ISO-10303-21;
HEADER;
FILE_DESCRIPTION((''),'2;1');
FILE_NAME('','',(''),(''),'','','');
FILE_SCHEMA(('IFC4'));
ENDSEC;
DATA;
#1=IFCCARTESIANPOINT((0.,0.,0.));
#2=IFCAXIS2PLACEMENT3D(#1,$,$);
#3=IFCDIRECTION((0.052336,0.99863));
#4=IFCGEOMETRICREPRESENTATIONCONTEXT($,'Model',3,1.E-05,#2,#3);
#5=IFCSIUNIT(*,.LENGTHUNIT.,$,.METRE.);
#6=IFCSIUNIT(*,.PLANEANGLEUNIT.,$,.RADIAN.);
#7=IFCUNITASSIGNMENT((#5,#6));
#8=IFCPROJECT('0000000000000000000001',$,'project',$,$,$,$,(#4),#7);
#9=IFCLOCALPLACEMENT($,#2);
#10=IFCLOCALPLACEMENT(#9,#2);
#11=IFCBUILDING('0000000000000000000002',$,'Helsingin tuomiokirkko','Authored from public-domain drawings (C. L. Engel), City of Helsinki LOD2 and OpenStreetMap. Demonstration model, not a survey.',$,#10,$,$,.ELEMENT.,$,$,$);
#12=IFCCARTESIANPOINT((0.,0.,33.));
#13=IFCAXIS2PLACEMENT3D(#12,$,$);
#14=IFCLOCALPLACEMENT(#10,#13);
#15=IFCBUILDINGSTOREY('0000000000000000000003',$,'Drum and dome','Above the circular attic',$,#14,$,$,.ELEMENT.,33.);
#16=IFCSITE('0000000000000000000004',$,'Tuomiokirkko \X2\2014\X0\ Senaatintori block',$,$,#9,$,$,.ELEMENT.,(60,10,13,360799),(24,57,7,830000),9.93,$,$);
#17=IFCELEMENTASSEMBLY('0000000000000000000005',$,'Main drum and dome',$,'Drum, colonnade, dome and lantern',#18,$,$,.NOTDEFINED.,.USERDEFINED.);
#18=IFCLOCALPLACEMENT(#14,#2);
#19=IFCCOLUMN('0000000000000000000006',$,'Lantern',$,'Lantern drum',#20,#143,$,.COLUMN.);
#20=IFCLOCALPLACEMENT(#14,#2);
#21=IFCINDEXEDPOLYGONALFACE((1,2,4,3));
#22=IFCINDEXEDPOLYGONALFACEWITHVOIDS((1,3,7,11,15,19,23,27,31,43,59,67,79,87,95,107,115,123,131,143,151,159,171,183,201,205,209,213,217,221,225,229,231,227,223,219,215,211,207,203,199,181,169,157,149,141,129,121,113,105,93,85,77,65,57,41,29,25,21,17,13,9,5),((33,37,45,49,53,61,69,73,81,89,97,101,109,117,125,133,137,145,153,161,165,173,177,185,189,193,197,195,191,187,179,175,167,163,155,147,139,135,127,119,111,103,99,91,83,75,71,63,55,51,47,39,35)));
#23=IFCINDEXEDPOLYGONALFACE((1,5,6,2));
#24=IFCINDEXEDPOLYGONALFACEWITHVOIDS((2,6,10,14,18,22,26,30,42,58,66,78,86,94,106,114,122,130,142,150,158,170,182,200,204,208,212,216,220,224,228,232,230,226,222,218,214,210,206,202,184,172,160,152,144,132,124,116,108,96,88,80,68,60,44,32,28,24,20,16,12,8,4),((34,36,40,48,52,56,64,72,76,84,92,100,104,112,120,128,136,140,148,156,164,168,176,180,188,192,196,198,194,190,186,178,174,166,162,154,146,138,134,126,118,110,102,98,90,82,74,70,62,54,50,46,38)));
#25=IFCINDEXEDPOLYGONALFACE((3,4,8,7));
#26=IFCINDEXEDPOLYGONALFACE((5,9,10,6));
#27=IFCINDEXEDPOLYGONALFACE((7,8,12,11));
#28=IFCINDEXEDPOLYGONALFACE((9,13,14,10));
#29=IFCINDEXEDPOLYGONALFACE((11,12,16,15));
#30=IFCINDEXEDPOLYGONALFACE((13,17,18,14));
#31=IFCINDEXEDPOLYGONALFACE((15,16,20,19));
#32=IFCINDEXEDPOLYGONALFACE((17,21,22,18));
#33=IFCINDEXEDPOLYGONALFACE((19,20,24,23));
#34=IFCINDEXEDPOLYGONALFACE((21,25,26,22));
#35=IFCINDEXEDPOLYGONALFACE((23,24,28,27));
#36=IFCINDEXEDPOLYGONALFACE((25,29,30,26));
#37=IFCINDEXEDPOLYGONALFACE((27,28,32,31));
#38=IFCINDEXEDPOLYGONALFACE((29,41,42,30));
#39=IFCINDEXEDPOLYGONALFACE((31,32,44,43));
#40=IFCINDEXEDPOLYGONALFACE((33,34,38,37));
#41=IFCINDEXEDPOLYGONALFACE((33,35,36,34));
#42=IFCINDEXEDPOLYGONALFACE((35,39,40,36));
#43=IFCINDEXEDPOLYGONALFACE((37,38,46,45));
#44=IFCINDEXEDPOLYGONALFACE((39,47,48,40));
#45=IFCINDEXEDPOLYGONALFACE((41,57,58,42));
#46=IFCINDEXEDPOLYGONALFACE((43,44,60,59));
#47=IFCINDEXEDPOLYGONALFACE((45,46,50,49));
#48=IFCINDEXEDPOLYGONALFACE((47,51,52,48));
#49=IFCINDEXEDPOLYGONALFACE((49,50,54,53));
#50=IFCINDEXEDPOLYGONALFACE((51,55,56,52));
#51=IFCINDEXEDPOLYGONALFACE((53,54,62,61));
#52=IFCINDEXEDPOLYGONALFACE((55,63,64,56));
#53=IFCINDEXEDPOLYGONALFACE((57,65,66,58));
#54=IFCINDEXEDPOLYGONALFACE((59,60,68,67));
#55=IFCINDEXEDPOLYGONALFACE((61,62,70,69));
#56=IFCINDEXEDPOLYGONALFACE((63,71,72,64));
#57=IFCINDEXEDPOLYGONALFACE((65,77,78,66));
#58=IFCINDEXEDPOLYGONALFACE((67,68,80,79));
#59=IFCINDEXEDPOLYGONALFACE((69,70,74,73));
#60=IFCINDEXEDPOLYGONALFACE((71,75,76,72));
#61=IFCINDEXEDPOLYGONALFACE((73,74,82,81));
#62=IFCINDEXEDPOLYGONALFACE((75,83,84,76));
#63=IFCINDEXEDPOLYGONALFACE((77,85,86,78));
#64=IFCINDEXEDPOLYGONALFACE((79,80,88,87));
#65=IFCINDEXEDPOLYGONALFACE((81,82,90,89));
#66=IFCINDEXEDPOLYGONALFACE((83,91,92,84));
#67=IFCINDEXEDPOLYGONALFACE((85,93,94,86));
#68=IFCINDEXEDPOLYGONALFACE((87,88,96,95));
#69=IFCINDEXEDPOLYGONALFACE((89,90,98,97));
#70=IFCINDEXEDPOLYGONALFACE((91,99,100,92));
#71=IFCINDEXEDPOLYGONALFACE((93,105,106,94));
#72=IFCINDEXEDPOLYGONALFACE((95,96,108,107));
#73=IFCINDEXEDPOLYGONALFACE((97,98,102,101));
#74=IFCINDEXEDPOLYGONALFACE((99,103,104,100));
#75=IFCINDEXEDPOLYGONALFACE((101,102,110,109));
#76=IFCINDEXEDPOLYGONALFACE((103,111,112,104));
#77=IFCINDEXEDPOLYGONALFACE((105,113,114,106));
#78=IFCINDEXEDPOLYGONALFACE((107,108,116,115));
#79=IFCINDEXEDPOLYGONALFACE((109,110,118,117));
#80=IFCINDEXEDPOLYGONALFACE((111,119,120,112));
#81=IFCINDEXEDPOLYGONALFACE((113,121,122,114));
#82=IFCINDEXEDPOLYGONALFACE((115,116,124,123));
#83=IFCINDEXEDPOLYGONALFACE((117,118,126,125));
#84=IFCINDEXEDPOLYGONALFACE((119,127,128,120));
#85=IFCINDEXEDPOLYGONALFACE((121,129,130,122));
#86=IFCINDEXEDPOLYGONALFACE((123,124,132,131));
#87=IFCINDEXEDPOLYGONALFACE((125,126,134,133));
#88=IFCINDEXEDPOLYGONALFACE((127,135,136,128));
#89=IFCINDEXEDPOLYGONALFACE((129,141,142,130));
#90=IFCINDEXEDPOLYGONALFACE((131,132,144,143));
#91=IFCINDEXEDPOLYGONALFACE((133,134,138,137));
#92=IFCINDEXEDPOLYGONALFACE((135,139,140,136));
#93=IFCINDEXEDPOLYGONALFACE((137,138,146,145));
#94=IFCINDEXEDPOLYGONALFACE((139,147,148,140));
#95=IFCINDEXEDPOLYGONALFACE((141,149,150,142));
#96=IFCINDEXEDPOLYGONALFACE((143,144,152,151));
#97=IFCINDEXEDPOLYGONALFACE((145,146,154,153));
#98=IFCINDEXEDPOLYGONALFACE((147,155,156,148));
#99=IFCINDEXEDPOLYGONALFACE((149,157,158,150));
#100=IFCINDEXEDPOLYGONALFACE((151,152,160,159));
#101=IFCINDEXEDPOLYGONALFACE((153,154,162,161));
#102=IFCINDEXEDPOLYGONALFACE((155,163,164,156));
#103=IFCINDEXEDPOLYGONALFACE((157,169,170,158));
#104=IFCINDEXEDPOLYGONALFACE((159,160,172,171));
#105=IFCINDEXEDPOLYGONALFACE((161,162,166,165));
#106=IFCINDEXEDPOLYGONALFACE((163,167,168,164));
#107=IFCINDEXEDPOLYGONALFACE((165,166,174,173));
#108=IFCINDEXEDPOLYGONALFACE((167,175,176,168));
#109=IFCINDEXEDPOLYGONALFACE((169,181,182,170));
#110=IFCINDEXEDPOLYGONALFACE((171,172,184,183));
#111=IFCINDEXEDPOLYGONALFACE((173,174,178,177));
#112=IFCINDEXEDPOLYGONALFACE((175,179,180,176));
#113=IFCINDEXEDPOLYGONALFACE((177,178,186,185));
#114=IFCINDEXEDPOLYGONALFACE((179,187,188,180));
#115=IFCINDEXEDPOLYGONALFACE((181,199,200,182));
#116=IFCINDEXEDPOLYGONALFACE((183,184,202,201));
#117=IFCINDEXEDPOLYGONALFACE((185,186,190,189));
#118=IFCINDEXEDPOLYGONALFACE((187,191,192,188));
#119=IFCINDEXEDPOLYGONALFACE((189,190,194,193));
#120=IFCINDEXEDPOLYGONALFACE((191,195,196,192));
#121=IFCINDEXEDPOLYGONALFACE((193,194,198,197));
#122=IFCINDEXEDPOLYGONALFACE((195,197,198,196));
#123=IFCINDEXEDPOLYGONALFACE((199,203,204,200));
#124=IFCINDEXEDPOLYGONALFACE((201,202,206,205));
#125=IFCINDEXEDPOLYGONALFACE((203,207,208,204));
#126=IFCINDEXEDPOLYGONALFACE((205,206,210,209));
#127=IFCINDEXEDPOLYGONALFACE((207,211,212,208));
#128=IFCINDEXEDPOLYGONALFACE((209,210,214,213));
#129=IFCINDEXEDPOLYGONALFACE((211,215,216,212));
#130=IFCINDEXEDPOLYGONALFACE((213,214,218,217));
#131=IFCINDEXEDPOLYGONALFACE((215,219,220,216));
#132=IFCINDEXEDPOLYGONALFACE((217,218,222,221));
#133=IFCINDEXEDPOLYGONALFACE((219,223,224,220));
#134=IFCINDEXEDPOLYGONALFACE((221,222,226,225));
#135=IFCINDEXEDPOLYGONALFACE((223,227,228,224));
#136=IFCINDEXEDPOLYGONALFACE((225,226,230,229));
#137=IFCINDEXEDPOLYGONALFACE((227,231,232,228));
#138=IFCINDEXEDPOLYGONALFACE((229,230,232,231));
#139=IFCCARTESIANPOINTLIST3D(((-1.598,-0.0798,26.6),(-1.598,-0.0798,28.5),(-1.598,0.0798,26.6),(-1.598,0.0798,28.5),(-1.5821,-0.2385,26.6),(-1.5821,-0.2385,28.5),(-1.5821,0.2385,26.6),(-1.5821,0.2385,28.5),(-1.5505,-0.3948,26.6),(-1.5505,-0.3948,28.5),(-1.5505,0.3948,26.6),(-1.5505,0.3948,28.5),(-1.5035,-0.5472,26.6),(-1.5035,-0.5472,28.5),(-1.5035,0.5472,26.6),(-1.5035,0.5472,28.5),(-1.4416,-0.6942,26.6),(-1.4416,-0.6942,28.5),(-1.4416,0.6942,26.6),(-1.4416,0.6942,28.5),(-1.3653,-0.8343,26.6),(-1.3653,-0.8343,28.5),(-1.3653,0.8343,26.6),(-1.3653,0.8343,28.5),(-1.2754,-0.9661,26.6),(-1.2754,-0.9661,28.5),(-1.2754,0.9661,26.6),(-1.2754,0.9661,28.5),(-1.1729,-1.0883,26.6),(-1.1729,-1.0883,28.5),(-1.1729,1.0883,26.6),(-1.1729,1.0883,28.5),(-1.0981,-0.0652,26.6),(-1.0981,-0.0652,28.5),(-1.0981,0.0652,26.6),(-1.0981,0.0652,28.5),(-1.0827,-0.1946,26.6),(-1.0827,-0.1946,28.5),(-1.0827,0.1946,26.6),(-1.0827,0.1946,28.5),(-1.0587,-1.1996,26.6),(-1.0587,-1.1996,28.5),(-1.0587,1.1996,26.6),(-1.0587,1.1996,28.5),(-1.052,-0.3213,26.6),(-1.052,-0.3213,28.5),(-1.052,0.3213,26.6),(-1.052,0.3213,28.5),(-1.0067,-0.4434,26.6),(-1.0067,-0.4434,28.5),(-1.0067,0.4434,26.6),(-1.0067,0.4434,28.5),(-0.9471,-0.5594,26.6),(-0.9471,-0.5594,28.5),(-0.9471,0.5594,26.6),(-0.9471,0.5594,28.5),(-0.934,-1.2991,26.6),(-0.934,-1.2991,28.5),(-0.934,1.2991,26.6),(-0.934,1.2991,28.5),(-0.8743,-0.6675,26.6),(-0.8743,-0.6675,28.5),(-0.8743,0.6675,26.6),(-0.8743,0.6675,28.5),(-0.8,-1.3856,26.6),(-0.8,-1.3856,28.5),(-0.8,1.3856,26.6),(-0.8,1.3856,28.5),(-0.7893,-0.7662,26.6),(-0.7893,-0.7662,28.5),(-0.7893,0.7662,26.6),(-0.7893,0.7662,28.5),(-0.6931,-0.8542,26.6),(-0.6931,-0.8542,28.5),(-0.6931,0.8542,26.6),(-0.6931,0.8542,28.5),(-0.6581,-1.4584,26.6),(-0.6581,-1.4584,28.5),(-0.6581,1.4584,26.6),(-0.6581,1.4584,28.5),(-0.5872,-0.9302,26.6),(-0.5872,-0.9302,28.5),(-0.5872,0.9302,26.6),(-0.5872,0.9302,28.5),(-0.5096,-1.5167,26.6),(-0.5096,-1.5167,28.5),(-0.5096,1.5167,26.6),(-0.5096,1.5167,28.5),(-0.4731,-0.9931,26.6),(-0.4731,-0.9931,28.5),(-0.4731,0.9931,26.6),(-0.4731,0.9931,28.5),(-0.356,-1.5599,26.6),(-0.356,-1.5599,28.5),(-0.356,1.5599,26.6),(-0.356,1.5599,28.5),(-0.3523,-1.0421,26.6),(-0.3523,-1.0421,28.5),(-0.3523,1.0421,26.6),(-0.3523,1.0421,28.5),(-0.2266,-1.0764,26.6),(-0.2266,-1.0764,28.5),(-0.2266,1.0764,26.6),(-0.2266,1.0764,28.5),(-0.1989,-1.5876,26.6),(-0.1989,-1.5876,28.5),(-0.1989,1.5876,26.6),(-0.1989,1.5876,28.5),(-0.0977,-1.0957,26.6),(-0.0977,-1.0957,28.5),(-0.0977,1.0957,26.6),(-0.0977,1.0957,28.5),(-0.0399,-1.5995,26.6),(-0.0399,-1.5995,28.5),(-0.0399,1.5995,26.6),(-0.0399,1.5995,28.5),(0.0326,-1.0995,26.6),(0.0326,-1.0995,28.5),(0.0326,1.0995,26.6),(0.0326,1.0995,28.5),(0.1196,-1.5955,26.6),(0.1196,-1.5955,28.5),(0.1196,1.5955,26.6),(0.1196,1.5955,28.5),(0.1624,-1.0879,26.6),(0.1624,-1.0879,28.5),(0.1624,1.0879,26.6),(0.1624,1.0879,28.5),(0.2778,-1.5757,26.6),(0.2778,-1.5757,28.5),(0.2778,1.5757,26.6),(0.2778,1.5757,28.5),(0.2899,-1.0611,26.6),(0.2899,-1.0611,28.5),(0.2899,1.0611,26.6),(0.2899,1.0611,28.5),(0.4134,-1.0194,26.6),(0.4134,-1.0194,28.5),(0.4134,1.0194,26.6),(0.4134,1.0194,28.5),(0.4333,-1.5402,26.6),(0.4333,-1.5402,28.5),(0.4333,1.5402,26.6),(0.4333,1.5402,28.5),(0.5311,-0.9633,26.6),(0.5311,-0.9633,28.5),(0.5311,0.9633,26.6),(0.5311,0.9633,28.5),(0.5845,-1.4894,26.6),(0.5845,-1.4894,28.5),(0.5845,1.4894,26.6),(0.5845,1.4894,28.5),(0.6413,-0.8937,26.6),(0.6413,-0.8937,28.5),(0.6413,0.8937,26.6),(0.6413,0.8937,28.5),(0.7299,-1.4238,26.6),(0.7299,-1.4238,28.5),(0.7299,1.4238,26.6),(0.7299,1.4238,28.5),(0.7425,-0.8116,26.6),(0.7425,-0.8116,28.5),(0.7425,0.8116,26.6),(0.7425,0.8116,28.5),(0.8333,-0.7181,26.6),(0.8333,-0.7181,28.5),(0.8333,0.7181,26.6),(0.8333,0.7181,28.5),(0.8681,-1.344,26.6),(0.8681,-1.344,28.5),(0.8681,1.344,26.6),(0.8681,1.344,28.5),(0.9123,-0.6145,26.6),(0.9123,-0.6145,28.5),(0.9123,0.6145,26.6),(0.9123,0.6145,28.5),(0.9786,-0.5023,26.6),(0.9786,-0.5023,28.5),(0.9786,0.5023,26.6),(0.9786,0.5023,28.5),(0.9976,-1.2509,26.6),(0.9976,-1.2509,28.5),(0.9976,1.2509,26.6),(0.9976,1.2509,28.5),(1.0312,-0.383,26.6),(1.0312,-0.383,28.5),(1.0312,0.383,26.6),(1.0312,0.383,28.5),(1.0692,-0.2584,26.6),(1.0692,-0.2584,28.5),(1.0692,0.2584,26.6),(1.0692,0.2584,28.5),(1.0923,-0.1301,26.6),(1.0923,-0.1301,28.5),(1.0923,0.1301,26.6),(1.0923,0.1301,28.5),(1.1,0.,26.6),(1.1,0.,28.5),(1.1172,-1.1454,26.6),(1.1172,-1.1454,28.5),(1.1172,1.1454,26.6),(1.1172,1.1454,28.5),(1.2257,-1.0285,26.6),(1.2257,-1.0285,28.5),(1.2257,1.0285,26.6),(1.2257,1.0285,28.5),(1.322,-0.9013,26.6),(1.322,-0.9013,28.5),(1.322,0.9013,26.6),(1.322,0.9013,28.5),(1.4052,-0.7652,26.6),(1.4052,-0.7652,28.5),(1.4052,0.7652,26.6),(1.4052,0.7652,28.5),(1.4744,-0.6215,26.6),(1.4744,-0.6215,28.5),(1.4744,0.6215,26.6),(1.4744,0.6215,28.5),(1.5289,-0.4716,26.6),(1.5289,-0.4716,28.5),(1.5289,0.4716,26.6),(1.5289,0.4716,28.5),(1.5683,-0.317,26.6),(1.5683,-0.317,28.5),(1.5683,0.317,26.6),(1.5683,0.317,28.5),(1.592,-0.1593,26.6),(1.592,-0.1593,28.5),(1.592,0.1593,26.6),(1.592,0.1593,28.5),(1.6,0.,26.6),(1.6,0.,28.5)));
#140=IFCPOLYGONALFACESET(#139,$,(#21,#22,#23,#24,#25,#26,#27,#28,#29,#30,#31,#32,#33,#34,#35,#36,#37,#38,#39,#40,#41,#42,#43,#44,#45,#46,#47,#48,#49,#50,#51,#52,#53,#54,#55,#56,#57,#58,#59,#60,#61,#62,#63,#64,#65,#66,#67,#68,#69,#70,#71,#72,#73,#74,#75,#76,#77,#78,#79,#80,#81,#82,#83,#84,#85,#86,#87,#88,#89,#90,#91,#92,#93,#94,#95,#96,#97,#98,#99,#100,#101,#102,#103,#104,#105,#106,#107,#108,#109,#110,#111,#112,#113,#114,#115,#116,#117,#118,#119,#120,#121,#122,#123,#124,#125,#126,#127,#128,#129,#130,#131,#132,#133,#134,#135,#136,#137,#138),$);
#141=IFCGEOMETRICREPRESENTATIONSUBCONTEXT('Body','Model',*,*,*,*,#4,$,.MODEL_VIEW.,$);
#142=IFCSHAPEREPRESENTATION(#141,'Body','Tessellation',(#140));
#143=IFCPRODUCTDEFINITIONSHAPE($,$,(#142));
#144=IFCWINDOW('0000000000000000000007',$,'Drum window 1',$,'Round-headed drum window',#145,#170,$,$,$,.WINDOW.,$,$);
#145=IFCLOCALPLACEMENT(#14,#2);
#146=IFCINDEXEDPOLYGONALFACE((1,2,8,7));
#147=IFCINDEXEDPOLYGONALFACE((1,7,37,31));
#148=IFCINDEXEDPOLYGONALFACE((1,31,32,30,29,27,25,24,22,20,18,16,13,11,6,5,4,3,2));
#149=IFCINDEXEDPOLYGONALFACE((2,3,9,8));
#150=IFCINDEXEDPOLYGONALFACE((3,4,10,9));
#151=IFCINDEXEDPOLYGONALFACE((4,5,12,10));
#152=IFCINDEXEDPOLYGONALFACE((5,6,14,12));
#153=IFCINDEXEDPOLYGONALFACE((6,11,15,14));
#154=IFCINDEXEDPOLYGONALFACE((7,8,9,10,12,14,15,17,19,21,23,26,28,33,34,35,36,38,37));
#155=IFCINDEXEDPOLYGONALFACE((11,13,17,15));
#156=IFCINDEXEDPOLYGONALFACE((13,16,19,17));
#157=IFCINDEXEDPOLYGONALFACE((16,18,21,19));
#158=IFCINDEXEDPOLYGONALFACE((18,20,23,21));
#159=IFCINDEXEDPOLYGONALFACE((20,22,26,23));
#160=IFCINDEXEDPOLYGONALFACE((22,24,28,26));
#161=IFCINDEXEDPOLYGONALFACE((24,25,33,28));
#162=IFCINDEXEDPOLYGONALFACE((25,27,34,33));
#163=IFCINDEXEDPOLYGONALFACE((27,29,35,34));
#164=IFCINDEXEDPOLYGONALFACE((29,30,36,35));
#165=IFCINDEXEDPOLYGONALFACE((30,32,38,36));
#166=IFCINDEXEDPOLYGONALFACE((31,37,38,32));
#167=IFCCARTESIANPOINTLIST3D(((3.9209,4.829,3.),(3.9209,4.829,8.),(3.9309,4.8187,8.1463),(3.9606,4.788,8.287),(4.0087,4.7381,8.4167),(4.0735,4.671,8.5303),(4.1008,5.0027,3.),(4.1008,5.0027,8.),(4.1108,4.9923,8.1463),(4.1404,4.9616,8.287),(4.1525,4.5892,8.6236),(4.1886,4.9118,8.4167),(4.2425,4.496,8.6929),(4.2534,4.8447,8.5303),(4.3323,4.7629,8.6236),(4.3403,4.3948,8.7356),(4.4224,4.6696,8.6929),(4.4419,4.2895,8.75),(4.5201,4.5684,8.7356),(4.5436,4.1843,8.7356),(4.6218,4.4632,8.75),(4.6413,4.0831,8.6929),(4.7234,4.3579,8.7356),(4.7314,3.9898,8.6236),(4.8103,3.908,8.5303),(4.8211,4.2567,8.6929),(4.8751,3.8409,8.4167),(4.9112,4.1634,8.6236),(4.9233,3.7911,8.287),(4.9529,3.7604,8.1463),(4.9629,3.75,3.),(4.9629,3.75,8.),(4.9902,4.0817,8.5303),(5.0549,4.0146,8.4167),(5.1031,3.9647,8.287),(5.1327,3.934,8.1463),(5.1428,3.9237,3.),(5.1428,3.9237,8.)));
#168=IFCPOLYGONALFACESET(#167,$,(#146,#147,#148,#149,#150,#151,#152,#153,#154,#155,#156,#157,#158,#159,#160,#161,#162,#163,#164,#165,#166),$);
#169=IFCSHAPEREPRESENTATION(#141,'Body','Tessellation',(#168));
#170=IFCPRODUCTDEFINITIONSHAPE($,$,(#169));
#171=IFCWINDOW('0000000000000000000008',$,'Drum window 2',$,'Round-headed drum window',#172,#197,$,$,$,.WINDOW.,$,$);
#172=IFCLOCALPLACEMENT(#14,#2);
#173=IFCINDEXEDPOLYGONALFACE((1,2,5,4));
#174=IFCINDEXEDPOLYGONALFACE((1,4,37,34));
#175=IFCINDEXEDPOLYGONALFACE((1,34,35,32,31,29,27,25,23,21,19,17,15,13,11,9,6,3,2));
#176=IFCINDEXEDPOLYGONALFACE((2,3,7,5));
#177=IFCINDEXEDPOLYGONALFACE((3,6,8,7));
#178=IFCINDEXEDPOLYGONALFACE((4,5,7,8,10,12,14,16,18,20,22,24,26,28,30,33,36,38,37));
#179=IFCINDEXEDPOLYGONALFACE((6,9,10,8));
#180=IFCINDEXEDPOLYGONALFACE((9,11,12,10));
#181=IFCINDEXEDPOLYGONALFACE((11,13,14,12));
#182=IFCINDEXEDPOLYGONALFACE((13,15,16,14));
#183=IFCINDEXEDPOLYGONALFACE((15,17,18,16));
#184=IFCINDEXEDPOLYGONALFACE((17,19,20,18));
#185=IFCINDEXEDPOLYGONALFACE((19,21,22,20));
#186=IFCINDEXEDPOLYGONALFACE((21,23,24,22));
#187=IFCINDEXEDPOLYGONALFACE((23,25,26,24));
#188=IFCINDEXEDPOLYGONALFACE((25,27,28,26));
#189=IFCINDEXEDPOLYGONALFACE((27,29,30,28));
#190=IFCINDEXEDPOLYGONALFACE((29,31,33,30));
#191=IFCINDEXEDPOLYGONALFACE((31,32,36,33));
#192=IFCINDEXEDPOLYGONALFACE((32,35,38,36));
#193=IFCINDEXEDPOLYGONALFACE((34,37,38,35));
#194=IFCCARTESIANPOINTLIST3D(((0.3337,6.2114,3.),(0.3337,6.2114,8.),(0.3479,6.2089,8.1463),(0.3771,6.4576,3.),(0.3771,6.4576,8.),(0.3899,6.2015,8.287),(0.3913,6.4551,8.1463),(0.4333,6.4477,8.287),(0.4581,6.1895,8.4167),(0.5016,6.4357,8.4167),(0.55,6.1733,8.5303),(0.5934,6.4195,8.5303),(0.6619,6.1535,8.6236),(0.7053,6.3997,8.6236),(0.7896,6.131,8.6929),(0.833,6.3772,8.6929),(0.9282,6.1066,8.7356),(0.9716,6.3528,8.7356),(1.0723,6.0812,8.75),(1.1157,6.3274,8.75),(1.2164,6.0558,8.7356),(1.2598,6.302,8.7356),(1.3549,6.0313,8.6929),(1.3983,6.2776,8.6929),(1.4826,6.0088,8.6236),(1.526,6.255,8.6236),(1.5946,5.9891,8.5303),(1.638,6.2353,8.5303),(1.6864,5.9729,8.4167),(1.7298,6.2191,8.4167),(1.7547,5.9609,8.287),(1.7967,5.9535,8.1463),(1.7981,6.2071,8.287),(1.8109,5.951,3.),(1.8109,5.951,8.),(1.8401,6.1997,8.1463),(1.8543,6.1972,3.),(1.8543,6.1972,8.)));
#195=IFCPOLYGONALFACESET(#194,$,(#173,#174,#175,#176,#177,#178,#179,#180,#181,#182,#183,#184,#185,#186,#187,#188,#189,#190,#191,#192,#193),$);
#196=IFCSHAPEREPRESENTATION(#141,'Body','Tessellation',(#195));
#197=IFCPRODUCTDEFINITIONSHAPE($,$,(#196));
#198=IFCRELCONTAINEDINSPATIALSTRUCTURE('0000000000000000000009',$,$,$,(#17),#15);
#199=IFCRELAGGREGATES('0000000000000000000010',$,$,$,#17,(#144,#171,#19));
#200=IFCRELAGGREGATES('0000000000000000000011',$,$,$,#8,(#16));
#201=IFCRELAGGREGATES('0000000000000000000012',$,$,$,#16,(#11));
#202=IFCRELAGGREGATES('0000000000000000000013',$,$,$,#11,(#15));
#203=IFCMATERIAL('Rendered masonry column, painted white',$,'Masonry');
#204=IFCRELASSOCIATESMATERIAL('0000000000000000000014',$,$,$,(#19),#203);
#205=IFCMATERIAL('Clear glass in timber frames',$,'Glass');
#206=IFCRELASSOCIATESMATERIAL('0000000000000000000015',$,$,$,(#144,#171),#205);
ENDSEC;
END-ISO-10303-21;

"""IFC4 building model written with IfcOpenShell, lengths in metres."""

from ifc_helpers import new_model, si_unit, direction, frame, origin, origin_2d_with_axis, place, context, subcontext, project, spatial, polyline, hollow_circle, outline, extrude, material, element, aggregate, save


model = new_model("IFC4")

# Units and contexts
model_context = context("Model", 3, precision=1e-05, world=origin(), true_north=direction((0.052336, 0.99863)))
body_context = subcontext(model_context, "Body", "Model", "MODEL_VIEW")
ifc_project = project(units=[si_unit("LENGTHUNIT", "METRE"), si_unit("PLANEANGLEUNIT", "RADIAN")], contexts=[model_context])

# Site, building, storey
site_placement = place(None, origin())
site = spatial("IfcSite", under=ifc_project, at=site_placement, Name="Tuomiokirkko — Senaatintori block", CompositionType="ELEMENT", RefLatitude=(60, 10, 13, 360799), RefLongitude=(24, 57, 7, 830000), RefElevation=9.93)
building_placement = place(site_placement, origin())
building = spatial("IfcBuilding", under=site, at=building_placement, Name="Helsingin tuomiokirkko", Description="Authored from public-domain drawings (C. L. Engel), City of Helsinki LOD2 and OpenStreetMap. Demonstration model, not a survey.", CompositionType="ELEMENT")
storey_placement = place(building_placement, frame((0.0, 0.0, 33.0)))
storey = spatial("IfcBuildingStorey", under=building, at=storey_placement, Name="Drum and dome", Description="Above the circular attic", CompositionType="ELEMENT", Elevation=33.0)

# Element assembly, column, windows
assembly_placement = place(building_placement, origin())
assembly = element("IfcElementAssembly", 1, at=assembly_placement, inside=storey, Name="Main drum and dome", ObjectType="Drum, colonnade, dome and lantern", AssemblyPlace="NOTDEFINED", PredefinedType="USERDEFINED")
ifc_material_1 = material(Name="Rendered masonry column, painted white", Category="Masonry")
column_1_placement = place(building_placement, origin())
column_1 = element("IfcColumn", 2, at=column_1_placement, material=ifc_material_1, Name="Lantern", ObjectType="Lantern drum", PredefinedType="COLUMN", context=body_context, shape_type="SweptSolid", body=[
    extrude(hollow_circle(Radius=1.6, WallThickness=0.5, at=origin_2d_with_axis()), frame((0.0, 0.0, 59.6)), (0.0, 0.0, 1.0), 1.9),
])
ifc_material_2 = material(Name="Clear glass in timber frames", Category="Glass")
window_1_placement = place(building_placement, origin())
window_1 = element("IfcWindow", 3, at=window_1_placement, material=ifc_material_2, Name="Drum window 1", ObjectType="Round-headed drum window", PredefinedType="WINDOW", context=body_context, shape_type="SweptSolid", body=[
    extrude(outline(polyline([(-0.75, 0.0), (0.75, 0.0), (0.75, 5.0), (0.7356, 5.1463), (0.6929, 5.287), (0.6236, 5.4167), (0.5303, 5.5303), (0.4167, 5.6236), (0.287, 5.6929), (0.1463, 5.7356), (0.0, 5.75), (-0.1463, 5.7356), (-0.287, 5.6929), (-0.4167, 5.6236), (-0.5303, 5.5303), (-0.6236, 5.4167), (-0.6929, 5.287), (-0.7356, 5.1463), (-0.75, 5.0), (-0.75, 0.0)])), frame((4.4419, 4.2895, 36.0), z_axis=(0.71934, 0.694658, 0.0), x_axis=(-0.694658, 0.71934, 0.0)), (0.0, 0.0, 1.0), 0.25),
])
window_2_placement = place(building_placement, origin())
window_2 = element("IfcWindow", 4, at=window_2_placement, material=ifc_material_2, Name="Drum window 2", ObjectType="Round-headed drum window", PredefinedType="WINDOW", context=body_context, shape_type="SweptSolid", body=[
    extrude(outline(polyline([(-0.75, 0.0), (0.75, 0.0), (0.75, 5.0), (0.7356, 5.1463), (0.6929, 5.287), (0.6236, 5.4167), (0.5303, 5.5303), (0.4167, 5.6236), (0.287, 5.6929), (0.1463, 5.7356), (0.0, 5.75), (-0.1463, 5.7356), (-0.287, 5.6929), (-0.4167, 5.6236), (-0.5303, 5.5303), (-0.6236, 5.4167), (-0.6929, 5.287), (-0.7356, 5.1463), (-0.75, 5.0), (-0.75, 0.0)])), frame((1.0723, 6.0812, 36.0), z_axis=(0.173648, 0.984808, 0.0), x_axis=(-0.984808, 0.173648, 0.0)), (0.0, 0.0, 1.0), 0.25),
])
aggregate(assembly, [window_1, window_2, column_1])

save(model, "model.ifc")
